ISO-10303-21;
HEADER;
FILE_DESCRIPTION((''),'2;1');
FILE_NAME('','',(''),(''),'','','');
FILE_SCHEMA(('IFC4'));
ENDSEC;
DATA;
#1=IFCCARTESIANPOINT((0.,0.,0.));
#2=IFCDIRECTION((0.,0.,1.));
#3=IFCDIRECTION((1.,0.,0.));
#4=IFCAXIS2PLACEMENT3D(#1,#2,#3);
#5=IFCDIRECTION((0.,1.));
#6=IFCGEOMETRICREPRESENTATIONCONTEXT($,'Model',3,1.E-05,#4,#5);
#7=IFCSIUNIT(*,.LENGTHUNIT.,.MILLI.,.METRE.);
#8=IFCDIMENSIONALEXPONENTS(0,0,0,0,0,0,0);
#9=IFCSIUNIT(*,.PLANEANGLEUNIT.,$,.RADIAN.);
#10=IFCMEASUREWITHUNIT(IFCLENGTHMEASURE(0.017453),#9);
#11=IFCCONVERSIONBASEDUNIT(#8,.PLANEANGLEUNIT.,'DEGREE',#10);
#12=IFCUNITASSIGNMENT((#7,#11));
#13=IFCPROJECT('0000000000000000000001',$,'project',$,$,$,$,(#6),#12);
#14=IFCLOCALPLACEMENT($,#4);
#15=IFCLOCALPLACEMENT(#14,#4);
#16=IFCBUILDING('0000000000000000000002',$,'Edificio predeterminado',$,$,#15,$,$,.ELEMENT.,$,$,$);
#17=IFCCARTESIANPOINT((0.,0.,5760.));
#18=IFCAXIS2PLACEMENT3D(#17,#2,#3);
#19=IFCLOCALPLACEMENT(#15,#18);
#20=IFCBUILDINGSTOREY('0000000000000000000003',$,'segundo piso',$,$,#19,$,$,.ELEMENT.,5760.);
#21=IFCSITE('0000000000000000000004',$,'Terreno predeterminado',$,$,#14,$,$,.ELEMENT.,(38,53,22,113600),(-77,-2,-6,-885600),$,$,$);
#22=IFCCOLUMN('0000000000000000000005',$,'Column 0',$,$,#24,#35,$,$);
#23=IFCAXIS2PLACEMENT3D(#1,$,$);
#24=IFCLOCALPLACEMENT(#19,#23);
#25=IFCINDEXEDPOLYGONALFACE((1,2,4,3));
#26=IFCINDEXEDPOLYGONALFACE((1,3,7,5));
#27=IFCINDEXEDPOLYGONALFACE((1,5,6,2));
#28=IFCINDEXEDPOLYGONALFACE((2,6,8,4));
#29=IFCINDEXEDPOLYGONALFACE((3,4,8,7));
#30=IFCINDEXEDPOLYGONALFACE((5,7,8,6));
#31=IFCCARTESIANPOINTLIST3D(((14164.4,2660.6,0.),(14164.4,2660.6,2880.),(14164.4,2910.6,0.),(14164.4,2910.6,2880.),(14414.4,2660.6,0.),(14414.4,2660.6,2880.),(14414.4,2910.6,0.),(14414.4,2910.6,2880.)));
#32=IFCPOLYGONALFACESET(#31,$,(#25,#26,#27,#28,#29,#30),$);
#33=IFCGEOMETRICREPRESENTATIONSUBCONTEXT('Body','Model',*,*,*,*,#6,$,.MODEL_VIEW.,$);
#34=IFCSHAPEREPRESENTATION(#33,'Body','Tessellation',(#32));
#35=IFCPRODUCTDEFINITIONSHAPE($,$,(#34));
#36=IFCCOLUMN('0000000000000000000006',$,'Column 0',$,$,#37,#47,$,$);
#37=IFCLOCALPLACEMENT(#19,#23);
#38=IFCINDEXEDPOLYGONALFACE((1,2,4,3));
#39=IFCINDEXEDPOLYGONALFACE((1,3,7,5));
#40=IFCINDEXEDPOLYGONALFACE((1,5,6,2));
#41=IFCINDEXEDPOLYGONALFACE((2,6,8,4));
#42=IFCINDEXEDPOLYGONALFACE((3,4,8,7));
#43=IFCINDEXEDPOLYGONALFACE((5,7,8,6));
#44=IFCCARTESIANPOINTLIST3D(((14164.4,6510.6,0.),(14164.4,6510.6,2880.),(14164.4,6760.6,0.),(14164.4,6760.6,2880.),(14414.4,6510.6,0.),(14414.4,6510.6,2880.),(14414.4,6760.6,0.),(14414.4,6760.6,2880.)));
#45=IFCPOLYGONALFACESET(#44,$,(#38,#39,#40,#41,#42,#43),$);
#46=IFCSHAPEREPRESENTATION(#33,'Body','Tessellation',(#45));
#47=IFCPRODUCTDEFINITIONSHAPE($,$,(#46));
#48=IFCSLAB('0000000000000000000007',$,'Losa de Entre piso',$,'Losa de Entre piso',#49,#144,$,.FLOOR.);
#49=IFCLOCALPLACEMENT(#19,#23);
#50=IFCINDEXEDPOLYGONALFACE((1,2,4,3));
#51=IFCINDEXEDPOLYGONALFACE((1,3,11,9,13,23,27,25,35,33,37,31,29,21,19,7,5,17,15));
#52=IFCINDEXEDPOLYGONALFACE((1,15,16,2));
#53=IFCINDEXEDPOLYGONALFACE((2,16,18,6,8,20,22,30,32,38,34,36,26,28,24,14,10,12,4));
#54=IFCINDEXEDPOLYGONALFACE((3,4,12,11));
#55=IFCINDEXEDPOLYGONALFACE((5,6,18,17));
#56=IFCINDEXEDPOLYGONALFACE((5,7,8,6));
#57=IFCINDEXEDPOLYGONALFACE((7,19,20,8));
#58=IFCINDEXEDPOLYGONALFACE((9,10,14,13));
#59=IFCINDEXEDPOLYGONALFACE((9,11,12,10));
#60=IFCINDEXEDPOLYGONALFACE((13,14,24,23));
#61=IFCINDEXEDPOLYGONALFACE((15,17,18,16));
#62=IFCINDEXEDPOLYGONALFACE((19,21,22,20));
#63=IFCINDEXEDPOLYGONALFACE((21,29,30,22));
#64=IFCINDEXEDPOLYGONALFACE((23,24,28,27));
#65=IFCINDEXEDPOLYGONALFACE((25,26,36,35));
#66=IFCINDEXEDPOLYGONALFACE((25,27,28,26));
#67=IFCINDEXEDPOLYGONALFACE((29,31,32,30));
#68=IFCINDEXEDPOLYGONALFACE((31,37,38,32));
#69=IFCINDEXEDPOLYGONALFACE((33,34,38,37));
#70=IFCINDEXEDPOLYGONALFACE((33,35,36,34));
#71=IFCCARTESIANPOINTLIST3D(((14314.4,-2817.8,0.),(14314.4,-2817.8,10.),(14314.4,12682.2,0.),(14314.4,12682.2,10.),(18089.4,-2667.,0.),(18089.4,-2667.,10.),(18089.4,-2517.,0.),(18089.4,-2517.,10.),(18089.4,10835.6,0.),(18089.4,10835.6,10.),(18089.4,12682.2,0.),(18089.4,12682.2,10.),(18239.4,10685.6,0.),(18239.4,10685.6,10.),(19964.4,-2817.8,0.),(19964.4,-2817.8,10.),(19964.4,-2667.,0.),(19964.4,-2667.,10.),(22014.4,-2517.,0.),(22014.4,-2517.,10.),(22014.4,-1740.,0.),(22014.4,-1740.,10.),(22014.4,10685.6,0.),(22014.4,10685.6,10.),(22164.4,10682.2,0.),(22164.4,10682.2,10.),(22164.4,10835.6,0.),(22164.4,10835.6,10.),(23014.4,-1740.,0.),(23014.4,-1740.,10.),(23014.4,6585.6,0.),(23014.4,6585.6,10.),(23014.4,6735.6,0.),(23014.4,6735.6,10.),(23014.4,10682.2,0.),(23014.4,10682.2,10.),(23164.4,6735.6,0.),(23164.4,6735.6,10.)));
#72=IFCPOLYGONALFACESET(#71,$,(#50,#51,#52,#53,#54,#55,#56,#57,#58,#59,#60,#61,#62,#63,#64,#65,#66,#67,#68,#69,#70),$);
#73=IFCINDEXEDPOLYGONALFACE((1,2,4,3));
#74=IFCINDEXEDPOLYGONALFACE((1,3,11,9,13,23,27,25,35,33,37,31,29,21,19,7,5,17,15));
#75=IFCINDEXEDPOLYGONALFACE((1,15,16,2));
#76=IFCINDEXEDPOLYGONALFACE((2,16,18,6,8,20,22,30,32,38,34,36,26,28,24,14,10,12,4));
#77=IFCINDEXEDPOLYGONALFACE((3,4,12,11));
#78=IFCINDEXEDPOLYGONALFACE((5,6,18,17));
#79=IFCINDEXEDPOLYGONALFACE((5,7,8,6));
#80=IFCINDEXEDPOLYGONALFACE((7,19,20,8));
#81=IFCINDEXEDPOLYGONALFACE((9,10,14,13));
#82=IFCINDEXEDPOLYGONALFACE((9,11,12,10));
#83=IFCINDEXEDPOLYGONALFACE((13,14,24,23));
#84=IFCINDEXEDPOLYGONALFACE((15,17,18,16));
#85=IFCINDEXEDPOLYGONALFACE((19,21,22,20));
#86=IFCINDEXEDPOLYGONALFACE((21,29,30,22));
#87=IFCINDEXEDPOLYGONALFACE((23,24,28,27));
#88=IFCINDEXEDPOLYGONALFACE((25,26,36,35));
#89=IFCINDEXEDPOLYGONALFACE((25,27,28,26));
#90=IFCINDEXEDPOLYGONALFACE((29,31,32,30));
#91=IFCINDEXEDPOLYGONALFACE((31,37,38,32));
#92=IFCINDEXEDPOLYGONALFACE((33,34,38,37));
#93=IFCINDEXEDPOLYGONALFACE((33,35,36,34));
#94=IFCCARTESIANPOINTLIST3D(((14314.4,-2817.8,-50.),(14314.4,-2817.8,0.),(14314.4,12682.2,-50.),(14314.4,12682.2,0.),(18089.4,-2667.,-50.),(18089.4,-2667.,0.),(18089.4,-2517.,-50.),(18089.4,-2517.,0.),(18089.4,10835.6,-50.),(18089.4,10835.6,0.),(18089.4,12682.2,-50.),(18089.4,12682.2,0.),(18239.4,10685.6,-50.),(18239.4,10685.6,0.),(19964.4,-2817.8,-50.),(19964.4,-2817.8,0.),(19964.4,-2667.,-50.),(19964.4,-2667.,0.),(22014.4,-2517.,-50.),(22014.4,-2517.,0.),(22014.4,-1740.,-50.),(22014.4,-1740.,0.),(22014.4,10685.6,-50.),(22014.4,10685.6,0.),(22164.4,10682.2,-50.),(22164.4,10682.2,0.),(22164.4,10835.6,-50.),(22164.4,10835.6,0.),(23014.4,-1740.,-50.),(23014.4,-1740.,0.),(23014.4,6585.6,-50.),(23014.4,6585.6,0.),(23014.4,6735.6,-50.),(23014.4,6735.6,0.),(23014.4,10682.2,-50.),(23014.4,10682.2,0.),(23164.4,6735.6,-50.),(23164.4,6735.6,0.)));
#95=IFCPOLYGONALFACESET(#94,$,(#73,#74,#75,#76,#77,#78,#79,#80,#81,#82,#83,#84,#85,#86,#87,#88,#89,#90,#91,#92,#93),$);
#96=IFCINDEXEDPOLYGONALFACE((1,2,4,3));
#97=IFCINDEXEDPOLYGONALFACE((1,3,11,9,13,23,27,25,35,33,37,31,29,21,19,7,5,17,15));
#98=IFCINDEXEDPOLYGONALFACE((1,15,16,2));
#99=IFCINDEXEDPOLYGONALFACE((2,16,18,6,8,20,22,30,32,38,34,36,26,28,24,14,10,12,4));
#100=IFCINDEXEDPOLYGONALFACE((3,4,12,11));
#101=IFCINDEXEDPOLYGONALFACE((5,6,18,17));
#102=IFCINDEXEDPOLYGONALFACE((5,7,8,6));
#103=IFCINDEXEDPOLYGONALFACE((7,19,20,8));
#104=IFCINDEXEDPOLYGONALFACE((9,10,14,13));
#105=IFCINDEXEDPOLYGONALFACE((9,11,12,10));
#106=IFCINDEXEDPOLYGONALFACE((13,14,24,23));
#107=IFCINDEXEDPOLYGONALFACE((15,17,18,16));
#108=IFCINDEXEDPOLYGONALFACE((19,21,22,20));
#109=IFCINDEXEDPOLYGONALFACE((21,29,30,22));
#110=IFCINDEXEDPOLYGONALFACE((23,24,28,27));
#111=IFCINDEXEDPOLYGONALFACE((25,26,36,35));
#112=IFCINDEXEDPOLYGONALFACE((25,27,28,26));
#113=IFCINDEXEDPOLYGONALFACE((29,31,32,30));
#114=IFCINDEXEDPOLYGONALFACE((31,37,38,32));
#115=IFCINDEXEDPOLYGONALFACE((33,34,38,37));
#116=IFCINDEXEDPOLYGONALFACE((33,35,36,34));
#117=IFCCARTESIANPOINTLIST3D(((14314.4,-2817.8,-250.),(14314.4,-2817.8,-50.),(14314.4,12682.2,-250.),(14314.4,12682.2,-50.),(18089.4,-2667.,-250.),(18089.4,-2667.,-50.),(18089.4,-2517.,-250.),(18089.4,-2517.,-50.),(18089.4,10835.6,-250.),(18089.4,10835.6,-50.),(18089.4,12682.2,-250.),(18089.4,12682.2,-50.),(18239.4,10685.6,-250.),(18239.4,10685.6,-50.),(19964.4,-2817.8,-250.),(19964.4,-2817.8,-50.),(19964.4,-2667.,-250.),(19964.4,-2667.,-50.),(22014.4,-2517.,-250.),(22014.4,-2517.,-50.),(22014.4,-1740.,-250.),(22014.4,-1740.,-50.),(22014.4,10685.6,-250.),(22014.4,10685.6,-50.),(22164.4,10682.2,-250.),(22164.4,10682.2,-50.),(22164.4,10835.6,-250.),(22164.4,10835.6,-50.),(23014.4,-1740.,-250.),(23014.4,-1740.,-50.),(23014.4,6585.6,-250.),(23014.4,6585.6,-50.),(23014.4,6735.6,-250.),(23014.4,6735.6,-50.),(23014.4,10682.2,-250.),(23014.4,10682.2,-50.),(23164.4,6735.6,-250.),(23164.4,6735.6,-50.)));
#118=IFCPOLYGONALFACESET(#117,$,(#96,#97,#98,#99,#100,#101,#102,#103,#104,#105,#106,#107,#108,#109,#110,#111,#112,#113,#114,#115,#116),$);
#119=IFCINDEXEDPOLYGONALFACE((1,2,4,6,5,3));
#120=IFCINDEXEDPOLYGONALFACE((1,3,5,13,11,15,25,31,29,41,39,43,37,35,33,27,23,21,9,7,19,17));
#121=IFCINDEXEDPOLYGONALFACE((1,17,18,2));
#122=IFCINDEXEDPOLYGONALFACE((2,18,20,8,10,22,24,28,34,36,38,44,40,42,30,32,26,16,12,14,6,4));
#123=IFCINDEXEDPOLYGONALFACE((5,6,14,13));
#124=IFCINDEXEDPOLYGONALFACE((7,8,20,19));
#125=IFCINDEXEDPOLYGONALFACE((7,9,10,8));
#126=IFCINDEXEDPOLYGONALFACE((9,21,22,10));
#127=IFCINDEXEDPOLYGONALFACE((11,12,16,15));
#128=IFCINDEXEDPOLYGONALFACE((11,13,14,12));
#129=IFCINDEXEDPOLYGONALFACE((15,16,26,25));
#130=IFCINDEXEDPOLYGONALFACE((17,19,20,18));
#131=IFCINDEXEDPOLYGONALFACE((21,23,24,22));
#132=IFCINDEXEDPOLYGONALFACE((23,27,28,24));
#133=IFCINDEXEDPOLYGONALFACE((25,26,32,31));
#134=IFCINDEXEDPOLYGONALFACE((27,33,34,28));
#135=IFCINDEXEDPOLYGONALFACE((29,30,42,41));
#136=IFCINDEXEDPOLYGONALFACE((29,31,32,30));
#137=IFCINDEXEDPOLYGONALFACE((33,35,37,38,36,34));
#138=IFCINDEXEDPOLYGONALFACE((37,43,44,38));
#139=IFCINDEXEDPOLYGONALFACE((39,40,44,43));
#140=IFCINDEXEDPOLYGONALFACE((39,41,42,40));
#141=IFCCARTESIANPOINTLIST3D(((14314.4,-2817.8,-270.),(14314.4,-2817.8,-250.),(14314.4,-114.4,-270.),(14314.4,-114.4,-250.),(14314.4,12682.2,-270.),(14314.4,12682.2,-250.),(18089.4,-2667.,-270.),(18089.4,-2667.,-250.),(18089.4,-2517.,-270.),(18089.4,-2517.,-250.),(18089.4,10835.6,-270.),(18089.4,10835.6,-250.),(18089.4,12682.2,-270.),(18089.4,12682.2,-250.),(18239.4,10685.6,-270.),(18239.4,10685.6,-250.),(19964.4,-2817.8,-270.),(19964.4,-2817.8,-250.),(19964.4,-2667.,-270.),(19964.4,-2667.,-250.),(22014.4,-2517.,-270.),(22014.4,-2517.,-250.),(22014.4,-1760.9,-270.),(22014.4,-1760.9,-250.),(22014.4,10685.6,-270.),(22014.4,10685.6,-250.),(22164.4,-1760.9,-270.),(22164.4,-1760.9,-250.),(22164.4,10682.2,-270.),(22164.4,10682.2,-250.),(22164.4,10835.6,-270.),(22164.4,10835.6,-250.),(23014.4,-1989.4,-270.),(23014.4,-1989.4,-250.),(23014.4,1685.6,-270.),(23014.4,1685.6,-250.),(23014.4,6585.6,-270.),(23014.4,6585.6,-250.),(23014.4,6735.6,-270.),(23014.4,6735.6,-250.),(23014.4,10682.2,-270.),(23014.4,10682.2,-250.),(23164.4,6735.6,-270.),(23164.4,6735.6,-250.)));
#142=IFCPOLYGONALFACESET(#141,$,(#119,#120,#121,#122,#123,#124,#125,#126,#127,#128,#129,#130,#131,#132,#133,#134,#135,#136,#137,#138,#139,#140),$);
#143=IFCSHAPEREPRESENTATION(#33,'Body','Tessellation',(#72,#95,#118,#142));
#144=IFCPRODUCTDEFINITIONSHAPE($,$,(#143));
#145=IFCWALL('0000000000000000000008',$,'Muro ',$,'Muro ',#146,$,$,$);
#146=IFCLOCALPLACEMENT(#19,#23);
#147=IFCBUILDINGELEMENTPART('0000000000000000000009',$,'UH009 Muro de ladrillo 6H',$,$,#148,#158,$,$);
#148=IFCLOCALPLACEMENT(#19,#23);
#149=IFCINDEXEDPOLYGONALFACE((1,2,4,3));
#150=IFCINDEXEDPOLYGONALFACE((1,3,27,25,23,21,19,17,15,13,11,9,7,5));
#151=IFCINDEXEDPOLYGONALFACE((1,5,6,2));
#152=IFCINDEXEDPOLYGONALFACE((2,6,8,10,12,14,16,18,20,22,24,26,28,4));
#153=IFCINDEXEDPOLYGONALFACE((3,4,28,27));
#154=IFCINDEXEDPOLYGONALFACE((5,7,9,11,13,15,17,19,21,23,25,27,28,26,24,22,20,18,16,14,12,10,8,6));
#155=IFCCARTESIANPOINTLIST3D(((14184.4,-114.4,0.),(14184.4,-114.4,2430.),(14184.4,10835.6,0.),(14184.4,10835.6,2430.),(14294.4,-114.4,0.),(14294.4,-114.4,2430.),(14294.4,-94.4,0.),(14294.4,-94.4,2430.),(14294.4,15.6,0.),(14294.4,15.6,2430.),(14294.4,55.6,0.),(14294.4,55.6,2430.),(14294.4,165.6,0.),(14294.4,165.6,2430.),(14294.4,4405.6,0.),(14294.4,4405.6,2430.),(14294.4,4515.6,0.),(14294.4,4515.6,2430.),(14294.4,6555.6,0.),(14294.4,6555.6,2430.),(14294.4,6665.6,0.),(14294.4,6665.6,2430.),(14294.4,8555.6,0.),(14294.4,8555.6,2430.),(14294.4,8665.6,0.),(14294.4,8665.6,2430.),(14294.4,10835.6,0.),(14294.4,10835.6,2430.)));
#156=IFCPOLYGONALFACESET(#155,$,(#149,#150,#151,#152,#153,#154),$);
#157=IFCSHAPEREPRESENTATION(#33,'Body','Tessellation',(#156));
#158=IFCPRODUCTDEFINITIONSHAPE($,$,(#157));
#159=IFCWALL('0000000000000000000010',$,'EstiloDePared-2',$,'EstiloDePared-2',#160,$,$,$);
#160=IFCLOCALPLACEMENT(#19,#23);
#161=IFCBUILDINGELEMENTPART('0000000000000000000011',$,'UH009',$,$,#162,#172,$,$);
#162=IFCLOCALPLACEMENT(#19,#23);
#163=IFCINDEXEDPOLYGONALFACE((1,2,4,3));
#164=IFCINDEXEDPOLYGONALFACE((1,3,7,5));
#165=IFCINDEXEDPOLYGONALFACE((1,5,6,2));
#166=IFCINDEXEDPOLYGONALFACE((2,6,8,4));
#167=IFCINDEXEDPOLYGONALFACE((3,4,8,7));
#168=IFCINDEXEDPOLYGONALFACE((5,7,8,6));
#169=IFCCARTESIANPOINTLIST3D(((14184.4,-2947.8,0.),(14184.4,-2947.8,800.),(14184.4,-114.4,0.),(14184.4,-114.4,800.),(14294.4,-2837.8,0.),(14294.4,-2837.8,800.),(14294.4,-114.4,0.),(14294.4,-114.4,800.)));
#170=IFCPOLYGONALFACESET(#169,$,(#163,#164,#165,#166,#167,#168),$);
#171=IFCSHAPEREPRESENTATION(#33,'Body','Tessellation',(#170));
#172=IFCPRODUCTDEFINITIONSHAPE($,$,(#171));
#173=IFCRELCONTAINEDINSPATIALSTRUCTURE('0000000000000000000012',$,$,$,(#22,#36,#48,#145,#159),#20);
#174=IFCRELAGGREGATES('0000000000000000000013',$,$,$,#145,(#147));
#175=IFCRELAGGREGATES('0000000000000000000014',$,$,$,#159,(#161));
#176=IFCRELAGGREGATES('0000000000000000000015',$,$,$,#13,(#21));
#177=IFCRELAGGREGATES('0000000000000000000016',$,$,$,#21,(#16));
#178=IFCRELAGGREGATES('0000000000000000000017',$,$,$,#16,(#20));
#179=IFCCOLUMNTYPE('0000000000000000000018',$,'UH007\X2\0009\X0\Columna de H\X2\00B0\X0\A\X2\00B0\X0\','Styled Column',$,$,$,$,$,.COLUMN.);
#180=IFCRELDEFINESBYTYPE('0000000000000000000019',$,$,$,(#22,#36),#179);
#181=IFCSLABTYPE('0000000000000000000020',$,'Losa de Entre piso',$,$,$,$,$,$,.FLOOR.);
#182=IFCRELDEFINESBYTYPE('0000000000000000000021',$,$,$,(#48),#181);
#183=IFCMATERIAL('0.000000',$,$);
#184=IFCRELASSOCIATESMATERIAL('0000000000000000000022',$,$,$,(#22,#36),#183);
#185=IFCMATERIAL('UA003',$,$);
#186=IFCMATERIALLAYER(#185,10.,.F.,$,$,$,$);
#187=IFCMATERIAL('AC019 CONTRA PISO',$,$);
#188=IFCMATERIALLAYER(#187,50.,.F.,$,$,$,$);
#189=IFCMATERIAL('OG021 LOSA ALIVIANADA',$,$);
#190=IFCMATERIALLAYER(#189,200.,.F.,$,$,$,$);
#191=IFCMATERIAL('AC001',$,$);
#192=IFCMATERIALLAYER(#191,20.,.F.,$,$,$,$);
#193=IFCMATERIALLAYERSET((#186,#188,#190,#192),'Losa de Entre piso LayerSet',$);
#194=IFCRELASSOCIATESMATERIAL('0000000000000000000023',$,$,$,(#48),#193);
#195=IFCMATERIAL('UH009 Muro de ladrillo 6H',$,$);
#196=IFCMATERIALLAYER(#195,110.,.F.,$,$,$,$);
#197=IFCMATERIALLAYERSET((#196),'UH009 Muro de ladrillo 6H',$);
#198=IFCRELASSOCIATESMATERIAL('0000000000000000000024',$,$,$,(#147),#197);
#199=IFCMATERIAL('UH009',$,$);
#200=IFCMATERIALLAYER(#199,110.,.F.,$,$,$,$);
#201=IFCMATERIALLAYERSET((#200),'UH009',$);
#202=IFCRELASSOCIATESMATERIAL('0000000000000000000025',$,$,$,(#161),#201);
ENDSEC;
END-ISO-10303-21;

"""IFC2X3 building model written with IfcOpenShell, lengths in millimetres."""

from ifc_helpers import new_model, entity, si_unit, converted_unit, direction, frame, origin_with_axes, place, context, subcontext, project, spatial, polyline, outline, extrude, material, layer, layer_set, layer_usage, type_object, element, aggregate, save


model = new_model("IFC2X3")

# Units and contexts
model_context = context("Model", 3, precision=1e-05, world=origin_with_axes(), true_north=direction((0.0, 1.0)))
body_context = subcontext(model_context, "Body", "Model", "MODEL_VIEW")
ifc_project = project(units=[si_unit("LENGTHUNIT", "METRE", prefix="MILLI"), converted_unit("PLANEANGLEUNIT", "DEGREE", entity("IfcLengthMeasure", 0.017453), si_unit("PLANEANGLEUNIT", "RADIAN"), dimensions=[0, 0, 0, 0, 0, 0, 0])], contexts=[model_context])

# Site, building, storey
site_placement = place(None, origin_with_axes())
site = spatial("IfcSite", under=ifc_project, at=site_placement, Name="Terreno predeterminado", CompositionType="ELEMENT", RefLatitude=(38, 53, 22, 113600), RefLongitude=(-77, -2, -6, -885600))
building_placement = place(site_placement, origin_with_axes())
building = spatial("IfcBuilding", under=site, at=building_placement, Name="Edificio predeterminado", CompositionType="ELEMENT")
storey_placement = place(building_placement, frame((0.0, 0.0, 5760.0), z_axis=(0.0, 0.0, 1.0), x_axis=(1.0, 0.0, 0.0)))
storey = spatial("IfcBuildingStorey", under=building, at=storey_placement, Name="segundo piso", CompositionType="ELEMENT", Elevation=5760.0)

# Columns
ifc_material_1 = material(Name="0.000000")
column_type = type_object("IfcColumnType", Name="UH007\tColumna de H°A°", Description="Styled Column", PredefinedType="COLUMN")
for number, where, z_axis, x_axis, name in (
    (1, (14289.4, 2785.6, 0.0), (0.0, 0.0, 1.0), (1.0, 0.0, 0.0), "Column 0"),
    (2, (14289.4, 6635.6, 0.0), (0.0, 0.0, 1.0), (1.0, 0.0, 0.0), "Column 0"),
):
    element("IfcColumn", number, at=place(storey_placement, frame(where, z_axis=z_axis, x_axis=x_axis)), inside=storey, type_object=column_type, material=ifc_material_1, Name=name, context=body_context, shape_type="SweptSolid", body=[
        extrude(outline(polyline([(-125.0, -125.0), (125.0, -125.0), (125.0, 125.0), (-125.0, 125.0), (-125.0, -125.0)])), origin_with_axes(), (0.0, 0.0, 1.0), 2880.0),
    ])

# Slab
ifc_material_2 = material(Name="UA003")
ifc_layer_1 = layer(ifc_material_2, 10.0, ventilated=False)
ifc_material_3 = material(Name="AC019 CONTRA PISO")
ifc_layer_2 = layer(ifc_material_3, 50.0, ventilated=False)
ifc_material_4 = material(Name="OG021 LOSA ALIVIANADA")
ifc_layer_3 = layer(ifc_material_4, 200.0, ventilated=False)
ifc_material_5 = material(Name="AC001")
ifc_layer_4 = layer(ifc_material_5, 20.0, ventilated=False)
ifc_layer_set_1 = layer_set([ifc_layer_1, ifc_layer_2, ifc_layer_3, ifc_layer_4], Name="Losa de Entre piso LayerSet")
ifc_layer_usage_1 = layer_usage(ifc_layer_set_1, "AXIS3", "POSITIVE", 0.0)
slab_type = type_object("IfcSlabType", Name="Losa de Entre piso", PredefinedType="FLOOR")
slab_placement = place(storey_placement, frame((0.0, 0.0, -5760.0), z_axis=(0.0, 0.0, 1.0), x_axis=(1.0, 0.0, 0.0)))
element("IfcSlab", 3, at=slab_placement, inside=storey, type_object=slab_type, material=ifc_layer_usage_1, Name="Losa de Entre piso", ObjectType="Losa de Entre piso", PredefinedType="FLOOR", context=body_context, shape_type="SweptSolid", body=[
    extrude(outline(polyline([(0.0, -777.0), (-1000.0, -777.0), (-1000.0, -9102.6), (-1150.0, -9252.6), (-1000.0, -9252.6), (-1000.0, -13199.1), (-150.0, -13199.1), (-150.0, -13352.6), (0.0, -13202.6), (3775.0, -13202.6), (3925.0, -13352.6), (3925.0, -15199.1), (7700.0, -15199.1), (7700.0, 300.9), (2050.0, 300.9), (2050.0, 150.0), (3925.0, 150.0), (3925.0, 0.0), (0.0, 0.0), (0.0, -777.0)])), frame((22014.4, -2517.0, 5760.0), z_axis=(0.0, 0.0, 1.0), x_axis=(-1.0, 0.0, 0.0)), (0.0, 0.0, 1.0), 10.0),
    extrude(outline(polyline([(0.0, -777.0), (-1000.0, -777.0), (-1000.0, -9102.6), (-1150.0, -9252.6), (-1000.0, -9252.6), (-1000.0, -13199.1), (-150.0, -13199.1), (-150.0, -13352.6), (0.0, -13202.6), (3775.0, -13202.6), (3925.0, -13352.6), (3925.0, -15199.1), (7700.0, -15199.1), (7700.0, 300.9), (2050.0, 300.9), (2050.0, 150.0), (3925.0, 150.0), (3925.0, 0.0), (0.0, 0.0), (0.0, -777.0)])), frame((22014.4, -2517.0, 5710.0), z_axis=(0.0, 0.0, 1.0), x_axis=(-1.0, 0.0, 0.0)), (0.0, 0.0, 1.0), 50.0),
    extrude(outline(polyline([(0.0, -777.0), (-1000.0, -777.0), (-1000.0, -9102.6), (-1150.0, -9252.6), (-1000.0, -9252.6), (-1000.0, -13199.1), (-150.0, -13199.1), (-150.0, -13352.6), (0.0, -13202.6), (3775.0, -13202.6), (3925.0, -13352.6), (3925.0, -15199.1), (7700.0, -15199.1), (7700.0, 300.9), (2050.0, 300.9), (2050.0, 150.0), (3925.0, 150.0), (3925.0, 0.0), (0.0, 0.0), (0.0, -777.0)])), frame((22014.4, -2517.0, 5510.0), z_axis=(0.0, 0.0, 1.0), x_axis=(-1.0, 0.0, 0.0)), (0.0, 0.0, 1.0), 200.0),
    extrude(outline(polyline([(-1305.7, 1305.7), (-3975.1, -1363.6), (5073.5, -10412.1), (6985.1, -12323.8), (10980.3, -8328.6), (10873.6, -8221.9), (9547.8, -9547.8), (9441.7, -9441.7), (12217.1, -6666.3), (11682.5, -6131.7), (11788.6, -6025.7), (12551.1, -5586.1), (9952.5, -2987.5), (6487.7, 477.3), (6487.7, 689.4), (6381.6, 583.4), (3591.0, 3374.0), (2990.0, 2773.0), (2881.5, 2881.5), (2881.5, 2669.3), (212.1, 0.0), (0.0, 0.0), (-1305.7, 1305.7)])), frame((18089.4, 10835.6, 5490.0), z_axis=(0.0, 0.0, 1.0), x_axis=(0.707107, -0.707107, 0.0)), (0.0, 0.0, 1.0), 20.0),
])

# Walls, building element parts
wall_1_placement = place(storey_placement, frame((14239.4, 10835.6, 0.0), z_axis=(0.0, 0.0, 1.0), x_axis=(0.0, -1.0, 0.0)))
wall_1 = element("IfcWall", 4, at=wall_1_placement, inside=storey, Name="Muro ", ObjectType="Muro ")
ifc_material_6 = material(Name="UH009 Muro de ladrillo 6H")
ifc_layer_5 = layer(ifc_material_6, 110.0, ventilated=False)
ifc_layer_set_2 = layer_set([ifc_layer_5], Name="UH009 Muro de ladrillo 6H")
ifc_layer_usage_2 = layer_usage(ifc_layer_set_2, "AXIS2", "NEGATIVE", -55.0)
building_element_part_1_placement = place(wall_1_placement, origin_with_axes())
building_element_part_1 = element("IfcBuildingElementPart", 5, at=building_element_part_1_placement, material=ifc_layer_usage_2, Name="UH009 Muro de ladrillo 6H", context=body_context, shape_type="SweptSolid", body=[
    extrude(outline(polyline([(4280.0, 55.0), (6320.0, 55.0), (6430.0, 55.0), (10670.0, 55.0), (10780.0, 55.0), (10820.0, 55.0), (10930.0, 55.0), (10950.0, 55.0), (10950.0, -55.0), (0.0, -55.0), (0.0, 55.0), (2170.0, 55.0), (2280.0, 55.0), (4170.0, 55.0), (4280.0, 55.0)])), origin_with_axes(), (0.0, 0.0, 1.0), 2430.0),
])
aggregate(wall_1, [building_element_part_1])
wall_2_placement = place(storey_placement, frame((14239.4, -2892.8, 0.0), z_axis=(0.0, 0.0, 1.0), x_axis=(0.0, 1.0, 0.0)))
wall_2 = element("IfcWall", 6, at=wall_2_placement, inside=storey, Name="EstiloDePared-2", ObjectType="EstiloDePared-2")
ifc_material_7 = material(Name="UH009")
ifc_layer_6 = layer(ifc_material_7, 110.0, ventilated=False)
ifc_layer_set_3 = layer_set([ifc_layer_6], Name="UH009")
ifc_layer_usage_3 = layer_usage(ifc_layer_set_3, "AXIS2", "NEGATIVE", -55.0)
building_element_part_2_placement = place(wall_2_placement, origin_with_axes())
building_element_part_2 = element("IfcBuildingElementPart", 7, at=building_element_part_2_placement, material=ifc_layer_usage_3, Name="UH009", context=body_context, shape_type="SweptSolid", body=[
    extrude(outline(polyline([(2778.4, 55.0), (2778.4, -55.0), (55.0, -55.0), (-55.0, 55.0), (2778.4, 55.0)])), origin_with_axes(), (0.0, 0.0, 1.0), 800.0),
])
aggregate(wall_2, [building_element_part_2])

save(model, "model.ifc")
